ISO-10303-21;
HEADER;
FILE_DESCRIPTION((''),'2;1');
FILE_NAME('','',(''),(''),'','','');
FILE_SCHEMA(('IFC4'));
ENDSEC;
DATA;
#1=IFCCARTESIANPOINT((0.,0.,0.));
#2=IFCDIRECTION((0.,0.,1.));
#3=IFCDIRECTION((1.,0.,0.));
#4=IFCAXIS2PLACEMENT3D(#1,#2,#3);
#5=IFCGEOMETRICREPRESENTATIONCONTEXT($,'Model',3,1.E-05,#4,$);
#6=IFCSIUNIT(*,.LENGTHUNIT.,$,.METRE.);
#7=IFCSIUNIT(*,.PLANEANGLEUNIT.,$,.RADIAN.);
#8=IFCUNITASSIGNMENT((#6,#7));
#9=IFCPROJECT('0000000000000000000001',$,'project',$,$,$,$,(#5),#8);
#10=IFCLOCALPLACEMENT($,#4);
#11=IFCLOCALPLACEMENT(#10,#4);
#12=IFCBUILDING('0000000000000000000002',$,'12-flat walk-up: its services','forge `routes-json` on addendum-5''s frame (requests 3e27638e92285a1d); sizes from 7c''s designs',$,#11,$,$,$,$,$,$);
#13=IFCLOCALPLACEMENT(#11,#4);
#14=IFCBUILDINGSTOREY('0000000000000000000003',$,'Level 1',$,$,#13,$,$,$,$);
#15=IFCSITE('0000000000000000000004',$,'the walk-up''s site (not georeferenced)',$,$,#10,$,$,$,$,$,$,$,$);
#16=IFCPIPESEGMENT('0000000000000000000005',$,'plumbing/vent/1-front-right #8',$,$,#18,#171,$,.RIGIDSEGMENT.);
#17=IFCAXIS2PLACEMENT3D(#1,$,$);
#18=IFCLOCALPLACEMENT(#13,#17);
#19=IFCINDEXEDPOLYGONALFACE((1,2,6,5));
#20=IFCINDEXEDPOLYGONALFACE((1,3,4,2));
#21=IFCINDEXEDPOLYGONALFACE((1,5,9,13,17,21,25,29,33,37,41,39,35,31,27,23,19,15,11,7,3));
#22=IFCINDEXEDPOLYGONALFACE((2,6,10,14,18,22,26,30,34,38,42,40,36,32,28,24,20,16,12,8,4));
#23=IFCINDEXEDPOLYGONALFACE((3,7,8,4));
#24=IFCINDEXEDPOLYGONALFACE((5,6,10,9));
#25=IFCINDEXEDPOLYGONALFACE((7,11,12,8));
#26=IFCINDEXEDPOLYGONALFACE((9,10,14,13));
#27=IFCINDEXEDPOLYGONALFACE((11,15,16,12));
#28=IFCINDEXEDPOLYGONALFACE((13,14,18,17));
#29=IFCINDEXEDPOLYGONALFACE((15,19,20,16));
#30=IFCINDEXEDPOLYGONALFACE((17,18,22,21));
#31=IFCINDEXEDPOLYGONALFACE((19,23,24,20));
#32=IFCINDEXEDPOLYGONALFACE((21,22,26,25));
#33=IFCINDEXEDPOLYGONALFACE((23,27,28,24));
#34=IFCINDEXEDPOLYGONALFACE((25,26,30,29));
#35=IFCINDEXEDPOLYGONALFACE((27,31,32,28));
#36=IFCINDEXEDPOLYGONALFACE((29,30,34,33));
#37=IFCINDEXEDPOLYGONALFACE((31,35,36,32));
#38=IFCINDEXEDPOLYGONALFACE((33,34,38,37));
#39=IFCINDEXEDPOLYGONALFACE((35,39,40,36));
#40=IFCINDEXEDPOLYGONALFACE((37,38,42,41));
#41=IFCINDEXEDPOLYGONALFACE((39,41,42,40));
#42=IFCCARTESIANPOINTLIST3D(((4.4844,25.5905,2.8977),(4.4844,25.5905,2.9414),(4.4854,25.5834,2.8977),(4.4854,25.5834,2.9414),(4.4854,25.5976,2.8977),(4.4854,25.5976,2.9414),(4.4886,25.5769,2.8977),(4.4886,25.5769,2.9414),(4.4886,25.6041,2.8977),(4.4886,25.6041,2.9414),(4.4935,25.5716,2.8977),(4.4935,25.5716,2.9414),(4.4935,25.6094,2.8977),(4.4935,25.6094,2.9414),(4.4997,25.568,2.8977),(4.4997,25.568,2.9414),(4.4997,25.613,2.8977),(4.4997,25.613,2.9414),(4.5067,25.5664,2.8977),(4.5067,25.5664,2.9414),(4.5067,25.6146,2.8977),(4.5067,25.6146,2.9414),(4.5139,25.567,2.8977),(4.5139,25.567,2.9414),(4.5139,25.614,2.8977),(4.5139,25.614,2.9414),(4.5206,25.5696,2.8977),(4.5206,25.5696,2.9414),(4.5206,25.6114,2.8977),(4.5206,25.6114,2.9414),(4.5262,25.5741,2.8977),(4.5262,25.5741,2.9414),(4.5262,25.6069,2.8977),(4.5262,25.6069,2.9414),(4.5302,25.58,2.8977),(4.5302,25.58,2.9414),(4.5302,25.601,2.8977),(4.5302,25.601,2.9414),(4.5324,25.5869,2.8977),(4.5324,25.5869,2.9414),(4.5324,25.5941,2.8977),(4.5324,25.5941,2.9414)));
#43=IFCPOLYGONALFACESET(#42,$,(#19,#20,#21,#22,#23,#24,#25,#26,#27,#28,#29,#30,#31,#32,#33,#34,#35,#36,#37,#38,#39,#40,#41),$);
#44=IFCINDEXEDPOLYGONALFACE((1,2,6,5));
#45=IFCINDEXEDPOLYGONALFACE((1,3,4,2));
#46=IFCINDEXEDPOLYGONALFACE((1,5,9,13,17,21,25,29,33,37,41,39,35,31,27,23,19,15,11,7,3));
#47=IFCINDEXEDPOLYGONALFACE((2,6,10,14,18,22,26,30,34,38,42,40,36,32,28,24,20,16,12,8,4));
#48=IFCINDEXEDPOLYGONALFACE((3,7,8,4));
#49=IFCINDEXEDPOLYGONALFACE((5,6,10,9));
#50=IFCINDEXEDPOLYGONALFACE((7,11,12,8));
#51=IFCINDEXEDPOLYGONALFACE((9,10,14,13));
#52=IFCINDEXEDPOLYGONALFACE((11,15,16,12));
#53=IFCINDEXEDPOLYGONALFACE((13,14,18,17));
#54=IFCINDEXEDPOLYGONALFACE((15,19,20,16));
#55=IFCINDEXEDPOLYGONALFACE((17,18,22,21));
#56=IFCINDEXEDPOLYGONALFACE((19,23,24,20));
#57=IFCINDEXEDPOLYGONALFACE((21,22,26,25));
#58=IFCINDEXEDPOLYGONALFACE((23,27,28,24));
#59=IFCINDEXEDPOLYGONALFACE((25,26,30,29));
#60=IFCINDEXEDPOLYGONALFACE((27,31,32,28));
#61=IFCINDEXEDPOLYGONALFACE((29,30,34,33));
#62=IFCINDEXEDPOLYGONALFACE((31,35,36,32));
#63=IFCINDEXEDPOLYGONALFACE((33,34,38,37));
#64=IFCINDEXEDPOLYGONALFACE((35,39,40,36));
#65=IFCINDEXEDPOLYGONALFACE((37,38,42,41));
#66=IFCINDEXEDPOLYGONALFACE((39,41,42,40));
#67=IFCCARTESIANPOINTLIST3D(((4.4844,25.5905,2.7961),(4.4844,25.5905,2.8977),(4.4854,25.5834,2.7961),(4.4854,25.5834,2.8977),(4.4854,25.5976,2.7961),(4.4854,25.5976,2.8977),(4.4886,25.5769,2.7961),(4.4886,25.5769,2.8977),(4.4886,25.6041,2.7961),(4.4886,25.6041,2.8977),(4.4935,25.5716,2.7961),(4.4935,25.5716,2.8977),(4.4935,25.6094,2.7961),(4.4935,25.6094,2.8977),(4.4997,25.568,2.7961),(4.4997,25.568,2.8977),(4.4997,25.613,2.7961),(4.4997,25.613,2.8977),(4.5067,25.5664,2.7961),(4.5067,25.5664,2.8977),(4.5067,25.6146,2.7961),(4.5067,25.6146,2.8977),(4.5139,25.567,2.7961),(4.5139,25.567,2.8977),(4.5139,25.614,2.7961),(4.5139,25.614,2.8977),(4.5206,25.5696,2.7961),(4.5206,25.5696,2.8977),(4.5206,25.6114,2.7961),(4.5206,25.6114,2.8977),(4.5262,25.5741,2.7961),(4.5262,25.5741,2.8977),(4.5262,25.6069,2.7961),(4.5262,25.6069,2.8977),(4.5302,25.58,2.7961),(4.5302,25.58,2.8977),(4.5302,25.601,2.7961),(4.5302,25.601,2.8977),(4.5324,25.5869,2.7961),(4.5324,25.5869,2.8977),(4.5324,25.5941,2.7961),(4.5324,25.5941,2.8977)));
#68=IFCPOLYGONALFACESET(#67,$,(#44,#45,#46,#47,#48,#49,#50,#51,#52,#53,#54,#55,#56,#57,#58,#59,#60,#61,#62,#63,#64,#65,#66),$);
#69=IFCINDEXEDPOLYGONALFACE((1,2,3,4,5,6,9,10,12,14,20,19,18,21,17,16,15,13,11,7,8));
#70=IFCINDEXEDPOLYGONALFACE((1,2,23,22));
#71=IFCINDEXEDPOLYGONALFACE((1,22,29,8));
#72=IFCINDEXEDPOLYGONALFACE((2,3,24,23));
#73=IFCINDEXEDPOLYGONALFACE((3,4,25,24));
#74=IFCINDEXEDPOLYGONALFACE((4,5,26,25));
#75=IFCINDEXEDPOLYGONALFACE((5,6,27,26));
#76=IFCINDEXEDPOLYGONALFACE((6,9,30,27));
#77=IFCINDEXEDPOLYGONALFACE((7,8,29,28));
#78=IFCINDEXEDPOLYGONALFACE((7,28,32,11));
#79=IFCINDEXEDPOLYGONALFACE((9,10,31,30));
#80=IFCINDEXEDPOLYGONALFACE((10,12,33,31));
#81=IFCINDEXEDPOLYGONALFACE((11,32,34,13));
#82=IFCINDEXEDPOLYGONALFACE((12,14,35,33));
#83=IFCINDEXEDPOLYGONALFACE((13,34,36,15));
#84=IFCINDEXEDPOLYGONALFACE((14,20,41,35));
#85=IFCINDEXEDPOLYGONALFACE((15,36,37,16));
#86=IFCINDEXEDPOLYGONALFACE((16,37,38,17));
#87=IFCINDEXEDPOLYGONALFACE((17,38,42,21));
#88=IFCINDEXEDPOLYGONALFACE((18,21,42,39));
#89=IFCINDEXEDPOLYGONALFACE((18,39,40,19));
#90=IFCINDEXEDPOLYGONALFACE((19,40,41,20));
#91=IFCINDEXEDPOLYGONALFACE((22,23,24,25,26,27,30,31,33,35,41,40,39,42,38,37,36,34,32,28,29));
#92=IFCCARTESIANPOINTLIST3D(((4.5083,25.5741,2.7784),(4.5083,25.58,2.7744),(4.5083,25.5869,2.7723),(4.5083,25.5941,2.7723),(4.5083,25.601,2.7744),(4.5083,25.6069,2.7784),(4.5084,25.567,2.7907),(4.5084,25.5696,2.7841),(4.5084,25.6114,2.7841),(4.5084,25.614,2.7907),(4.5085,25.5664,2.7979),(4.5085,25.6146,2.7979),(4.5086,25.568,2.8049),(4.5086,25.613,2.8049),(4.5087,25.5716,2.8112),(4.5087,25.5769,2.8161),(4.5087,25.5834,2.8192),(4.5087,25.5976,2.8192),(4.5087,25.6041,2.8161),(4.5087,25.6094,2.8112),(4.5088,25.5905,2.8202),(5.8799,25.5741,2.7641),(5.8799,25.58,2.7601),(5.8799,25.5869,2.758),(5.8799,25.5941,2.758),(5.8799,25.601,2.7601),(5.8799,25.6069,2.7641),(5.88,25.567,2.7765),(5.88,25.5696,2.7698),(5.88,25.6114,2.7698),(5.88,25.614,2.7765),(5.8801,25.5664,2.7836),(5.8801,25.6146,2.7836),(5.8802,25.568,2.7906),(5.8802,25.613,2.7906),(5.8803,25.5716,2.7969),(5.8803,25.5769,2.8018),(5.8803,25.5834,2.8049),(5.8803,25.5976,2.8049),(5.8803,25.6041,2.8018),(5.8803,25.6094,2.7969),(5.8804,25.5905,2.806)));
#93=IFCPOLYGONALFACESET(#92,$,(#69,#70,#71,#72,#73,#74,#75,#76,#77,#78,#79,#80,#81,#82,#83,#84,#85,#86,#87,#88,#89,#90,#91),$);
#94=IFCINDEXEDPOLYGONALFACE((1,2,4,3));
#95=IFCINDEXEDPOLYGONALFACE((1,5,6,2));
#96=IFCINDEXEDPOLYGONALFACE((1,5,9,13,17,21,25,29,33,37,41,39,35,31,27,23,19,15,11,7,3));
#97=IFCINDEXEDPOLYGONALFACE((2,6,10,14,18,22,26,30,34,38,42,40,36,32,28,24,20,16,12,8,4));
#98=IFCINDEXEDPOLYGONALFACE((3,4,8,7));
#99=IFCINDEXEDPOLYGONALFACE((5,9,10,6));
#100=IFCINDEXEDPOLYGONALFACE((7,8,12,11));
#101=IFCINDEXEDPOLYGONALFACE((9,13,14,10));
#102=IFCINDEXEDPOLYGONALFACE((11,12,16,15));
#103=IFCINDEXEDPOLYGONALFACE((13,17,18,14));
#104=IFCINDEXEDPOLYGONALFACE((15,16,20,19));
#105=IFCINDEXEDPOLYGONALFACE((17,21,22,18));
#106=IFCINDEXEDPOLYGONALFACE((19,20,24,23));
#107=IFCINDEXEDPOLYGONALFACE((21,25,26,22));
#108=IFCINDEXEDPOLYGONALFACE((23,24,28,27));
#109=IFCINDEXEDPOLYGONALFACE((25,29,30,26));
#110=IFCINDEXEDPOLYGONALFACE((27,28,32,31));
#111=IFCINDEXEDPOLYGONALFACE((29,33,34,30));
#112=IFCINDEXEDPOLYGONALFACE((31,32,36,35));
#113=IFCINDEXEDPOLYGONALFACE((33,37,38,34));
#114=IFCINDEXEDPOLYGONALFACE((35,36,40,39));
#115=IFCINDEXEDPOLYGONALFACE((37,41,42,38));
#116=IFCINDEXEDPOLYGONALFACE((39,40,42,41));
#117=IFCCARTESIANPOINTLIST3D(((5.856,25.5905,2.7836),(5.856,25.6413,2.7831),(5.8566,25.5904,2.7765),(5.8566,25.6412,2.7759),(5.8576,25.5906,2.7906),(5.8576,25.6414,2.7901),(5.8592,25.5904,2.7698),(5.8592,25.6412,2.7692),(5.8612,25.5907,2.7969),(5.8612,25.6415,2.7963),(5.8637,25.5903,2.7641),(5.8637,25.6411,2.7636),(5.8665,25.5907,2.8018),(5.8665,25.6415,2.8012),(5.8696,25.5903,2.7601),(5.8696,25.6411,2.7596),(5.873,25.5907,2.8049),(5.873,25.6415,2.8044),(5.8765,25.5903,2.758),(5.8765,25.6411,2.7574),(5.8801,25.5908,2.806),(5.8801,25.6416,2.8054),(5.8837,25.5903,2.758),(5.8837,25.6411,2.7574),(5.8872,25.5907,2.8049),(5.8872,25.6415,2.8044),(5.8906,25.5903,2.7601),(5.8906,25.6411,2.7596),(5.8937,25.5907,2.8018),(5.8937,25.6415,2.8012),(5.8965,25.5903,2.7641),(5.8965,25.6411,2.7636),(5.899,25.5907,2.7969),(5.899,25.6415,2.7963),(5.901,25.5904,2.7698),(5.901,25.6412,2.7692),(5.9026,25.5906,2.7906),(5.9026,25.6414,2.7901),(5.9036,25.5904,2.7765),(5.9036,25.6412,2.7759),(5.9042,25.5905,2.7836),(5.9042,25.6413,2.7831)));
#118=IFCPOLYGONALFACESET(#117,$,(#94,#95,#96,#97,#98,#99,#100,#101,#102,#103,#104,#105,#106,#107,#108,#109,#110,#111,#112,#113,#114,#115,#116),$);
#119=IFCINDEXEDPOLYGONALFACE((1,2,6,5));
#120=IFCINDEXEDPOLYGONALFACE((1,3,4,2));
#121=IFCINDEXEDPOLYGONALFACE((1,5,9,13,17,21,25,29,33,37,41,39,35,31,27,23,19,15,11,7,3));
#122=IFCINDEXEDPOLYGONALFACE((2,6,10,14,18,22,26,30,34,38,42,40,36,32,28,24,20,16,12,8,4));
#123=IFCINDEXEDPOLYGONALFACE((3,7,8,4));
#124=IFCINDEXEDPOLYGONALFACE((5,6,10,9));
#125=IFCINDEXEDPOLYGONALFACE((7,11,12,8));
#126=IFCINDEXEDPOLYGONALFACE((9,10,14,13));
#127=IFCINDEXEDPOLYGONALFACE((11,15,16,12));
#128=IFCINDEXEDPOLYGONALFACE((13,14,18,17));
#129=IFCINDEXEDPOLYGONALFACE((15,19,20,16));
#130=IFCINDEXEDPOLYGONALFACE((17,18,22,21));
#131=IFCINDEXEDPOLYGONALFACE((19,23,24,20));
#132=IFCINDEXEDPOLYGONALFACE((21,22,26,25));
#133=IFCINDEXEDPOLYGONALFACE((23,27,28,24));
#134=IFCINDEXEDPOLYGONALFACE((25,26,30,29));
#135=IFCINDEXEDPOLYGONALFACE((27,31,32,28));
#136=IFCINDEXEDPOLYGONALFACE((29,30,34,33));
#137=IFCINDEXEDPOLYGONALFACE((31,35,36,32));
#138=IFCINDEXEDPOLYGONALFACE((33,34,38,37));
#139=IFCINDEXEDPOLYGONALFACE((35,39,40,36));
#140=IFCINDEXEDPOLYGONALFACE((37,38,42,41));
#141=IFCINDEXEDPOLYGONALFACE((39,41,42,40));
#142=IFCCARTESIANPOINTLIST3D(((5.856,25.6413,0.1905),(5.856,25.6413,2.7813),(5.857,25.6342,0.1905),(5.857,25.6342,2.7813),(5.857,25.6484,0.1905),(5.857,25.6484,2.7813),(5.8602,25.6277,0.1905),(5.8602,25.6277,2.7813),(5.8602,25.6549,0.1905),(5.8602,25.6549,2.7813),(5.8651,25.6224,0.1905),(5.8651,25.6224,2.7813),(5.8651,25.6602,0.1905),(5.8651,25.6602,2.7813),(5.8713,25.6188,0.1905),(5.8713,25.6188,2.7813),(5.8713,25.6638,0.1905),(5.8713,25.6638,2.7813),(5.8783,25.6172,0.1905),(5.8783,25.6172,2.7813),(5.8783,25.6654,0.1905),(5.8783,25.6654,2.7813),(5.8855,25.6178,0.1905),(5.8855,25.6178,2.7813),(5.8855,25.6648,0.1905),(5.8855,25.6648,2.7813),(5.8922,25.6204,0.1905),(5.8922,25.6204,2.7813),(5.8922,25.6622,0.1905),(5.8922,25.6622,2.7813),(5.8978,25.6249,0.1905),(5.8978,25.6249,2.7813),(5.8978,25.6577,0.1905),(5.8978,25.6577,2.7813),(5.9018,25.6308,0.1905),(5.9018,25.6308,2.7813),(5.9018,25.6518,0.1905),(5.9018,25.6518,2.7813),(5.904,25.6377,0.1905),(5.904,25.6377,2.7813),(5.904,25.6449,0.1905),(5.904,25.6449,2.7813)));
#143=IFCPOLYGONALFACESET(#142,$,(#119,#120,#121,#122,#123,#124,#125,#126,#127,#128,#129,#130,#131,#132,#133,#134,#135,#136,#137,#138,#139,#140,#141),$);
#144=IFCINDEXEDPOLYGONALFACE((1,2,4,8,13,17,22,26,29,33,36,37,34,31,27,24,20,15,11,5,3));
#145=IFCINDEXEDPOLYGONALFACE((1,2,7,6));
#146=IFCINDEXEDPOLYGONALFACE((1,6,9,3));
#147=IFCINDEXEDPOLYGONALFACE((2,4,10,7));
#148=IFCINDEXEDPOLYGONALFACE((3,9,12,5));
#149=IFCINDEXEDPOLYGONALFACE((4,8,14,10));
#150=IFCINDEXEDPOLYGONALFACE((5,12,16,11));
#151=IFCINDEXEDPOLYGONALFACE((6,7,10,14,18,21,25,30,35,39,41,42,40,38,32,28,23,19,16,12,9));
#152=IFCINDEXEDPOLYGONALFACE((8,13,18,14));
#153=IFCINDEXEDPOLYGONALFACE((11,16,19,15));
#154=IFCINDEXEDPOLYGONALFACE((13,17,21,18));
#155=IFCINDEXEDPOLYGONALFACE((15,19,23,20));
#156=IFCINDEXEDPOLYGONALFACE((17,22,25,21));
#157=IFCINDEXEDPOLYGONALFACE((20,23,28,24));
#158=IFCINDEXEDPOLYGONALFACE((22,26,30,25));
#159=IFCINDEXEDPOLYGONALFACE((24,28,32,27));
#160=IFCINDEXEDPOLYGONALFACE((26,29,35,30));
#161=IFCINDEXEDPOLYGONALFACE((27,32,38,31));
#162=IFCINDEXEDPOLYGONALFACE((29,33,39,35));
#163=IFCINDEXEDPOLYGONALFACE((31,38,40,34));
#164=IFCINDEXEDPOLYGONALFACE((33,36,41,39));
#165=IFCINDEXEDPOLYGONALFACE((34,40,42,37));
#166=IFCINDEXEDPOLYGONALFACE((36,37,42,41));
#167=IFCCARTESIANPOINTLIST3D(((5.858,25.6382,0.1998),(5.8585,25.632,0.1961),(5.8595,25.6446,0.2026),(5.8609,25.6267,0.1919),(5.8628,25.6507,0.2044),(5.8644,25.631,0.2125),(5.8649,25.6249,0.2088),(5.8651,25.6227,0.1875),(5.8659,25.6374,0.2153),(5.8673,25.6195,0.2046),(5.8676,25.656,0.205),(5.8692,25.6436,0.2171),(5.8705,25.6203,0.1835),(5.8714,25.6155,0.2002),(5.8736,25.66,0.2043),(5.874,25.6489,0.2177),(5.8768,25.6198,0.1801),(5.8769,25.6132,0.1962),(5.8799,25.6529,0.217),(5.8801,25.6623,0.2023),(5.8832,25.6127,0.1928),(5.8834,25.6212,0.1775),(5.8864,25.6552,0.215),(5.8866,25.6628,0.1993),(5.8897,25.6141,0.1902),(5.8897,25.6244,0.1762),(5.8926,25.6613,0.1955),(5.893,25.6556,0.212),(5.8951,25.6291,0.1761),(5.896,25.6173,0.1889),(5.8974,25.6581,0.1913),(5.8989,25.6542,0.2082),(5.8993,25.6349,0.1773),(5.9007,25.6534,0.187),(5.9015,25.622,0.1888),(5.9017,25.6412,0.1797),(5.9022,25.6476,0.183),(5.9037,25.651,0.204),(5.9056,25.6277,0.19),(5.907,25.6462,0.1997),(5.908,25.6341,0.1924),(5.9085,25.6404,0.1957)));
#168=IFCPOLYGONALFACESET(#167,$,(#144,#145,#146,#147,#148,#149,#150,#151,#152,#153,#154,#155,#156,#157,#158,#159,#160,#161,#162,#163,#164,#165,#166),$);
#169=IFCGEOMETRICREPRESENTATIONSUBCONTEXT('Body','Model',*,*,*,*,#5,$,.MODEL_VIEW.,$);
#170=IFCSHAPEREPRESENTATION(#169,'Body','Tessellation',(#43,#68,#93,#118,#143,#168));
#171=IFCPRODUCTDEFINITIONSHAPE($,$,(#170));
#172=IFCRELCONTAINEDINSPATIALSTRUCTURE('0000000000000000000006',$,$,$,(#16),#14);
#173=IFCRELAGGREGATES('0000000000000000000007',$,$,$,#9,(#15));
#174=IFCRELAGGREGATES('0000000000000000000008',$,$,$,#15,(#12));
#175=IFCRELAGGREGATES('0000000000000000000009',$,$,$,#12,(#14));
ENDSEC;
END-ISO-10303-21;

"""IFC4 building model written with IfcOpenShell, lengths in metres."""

from ifc_helpers import new_model, entity, si_unit, frame, origin_with_axes, place, context, subcontext, project, spatial, element, save


model = new_model("IFC4")

# Units and contexts
model_context = context("Model", 3, precision=1e-05, world=origin_with_axes())
body_context = subcontext(model_context, "Body", "Model", "MODEL_VIEW")
ifc_project = project(units=[si_unit("LENGTHUNIT", "METRE"), si_unit("PLANEANGLEUNIT", "RADIAN")], contexts=[model_context])

# Site, building, storey
site_placement = place(None, origin_with_axes())
site = spatial("IfcSite", under=ifc_project, at=site_placement, Name="the walk-up's site (not georeferenced)")
building_placement = place(site_placement, origin_with_axes())
building = spatial("IfcBuilding", under=site, at=building_placement, Name="12-flat walk-up: its services", Description="forge `routes-json` on addendum-5's frame (requests 3e27638e92285a1d); sizes from 7c's designs")
storey_placement = place(building_placement, origin_with_axes())
storey = spatial("IfcBuildingStorey", under=building, at=storey_placement, Name="Level 1")

# Pipe segment
pipe_segment_1_placement = place(storey_placement, frame((4.5085, 25.5905, 2.9414), z_axis=(0.0, 0.0, 1.0), x_axis=(1.0, 0.0, 0.0)))
element("IfcPipeSegment", 1, at=pipe_segment_1_placement, inside=storey, Name="plumbing/vent/1-front-right #8", PredefinedType="RIGIDSEGMENT", context=body_context, shape_type="AdvancedSweptSolid", body=[
    entity("IfcSweptDiskSolid", entity("IfcPolyline", [entity("IfcCartesianPoint", [0.0, 0.0, 0.0]), entity("IfcCartesianPoint", [0.0, 0.0, -0.0437])]), 0.0241),
    entity("IfcSweptDiskSolid", entity("IfcPolyline", [entity("IfcCartesianPoint", [0.0, 0.0, -0.0437]), entity("IfcCartesianPoint", [0.0, 0.0, -0.1453])]), 0.0241),
    entity("IfcSweptDiskSolid", entity("IfcPolyline", [entity("IfcCartesianPoint", [0.0, 0.0, -0.1453]), entity("IfcCartesianPoint", [1.3716, 0.0, -0.1595])]), 0.0241),
    entity("IfcSweptDiskSolid", entity("IfcPolyline", [entity("IfcCartesianPoint", [1.3716, 0.0, -0.1595]), entity("IfcCartesianPoint", [1.3716, 0.0508, -0.1601])]), 0.0241),
    entity("IfcSweptDiskSolid", entity("IfcPolyline", [entity("IfcCartesianPoint", [1.3716, 0.0508, -0.1601]), entity("IfcCartesianPoint", [1.3716, 0.0508, -2.7509])]), 0.0241),
    entity("IfcSweptDiskSolid", entity("IfcPolyline", [entity("IfcCartesianPoint", [1.3716, 0.0508, -2.7509]), entity("IfcCartesianPoint", [1.378, 0.0437, -2.7382])]), 0.0241),
])

save(model, "model.ifc")
